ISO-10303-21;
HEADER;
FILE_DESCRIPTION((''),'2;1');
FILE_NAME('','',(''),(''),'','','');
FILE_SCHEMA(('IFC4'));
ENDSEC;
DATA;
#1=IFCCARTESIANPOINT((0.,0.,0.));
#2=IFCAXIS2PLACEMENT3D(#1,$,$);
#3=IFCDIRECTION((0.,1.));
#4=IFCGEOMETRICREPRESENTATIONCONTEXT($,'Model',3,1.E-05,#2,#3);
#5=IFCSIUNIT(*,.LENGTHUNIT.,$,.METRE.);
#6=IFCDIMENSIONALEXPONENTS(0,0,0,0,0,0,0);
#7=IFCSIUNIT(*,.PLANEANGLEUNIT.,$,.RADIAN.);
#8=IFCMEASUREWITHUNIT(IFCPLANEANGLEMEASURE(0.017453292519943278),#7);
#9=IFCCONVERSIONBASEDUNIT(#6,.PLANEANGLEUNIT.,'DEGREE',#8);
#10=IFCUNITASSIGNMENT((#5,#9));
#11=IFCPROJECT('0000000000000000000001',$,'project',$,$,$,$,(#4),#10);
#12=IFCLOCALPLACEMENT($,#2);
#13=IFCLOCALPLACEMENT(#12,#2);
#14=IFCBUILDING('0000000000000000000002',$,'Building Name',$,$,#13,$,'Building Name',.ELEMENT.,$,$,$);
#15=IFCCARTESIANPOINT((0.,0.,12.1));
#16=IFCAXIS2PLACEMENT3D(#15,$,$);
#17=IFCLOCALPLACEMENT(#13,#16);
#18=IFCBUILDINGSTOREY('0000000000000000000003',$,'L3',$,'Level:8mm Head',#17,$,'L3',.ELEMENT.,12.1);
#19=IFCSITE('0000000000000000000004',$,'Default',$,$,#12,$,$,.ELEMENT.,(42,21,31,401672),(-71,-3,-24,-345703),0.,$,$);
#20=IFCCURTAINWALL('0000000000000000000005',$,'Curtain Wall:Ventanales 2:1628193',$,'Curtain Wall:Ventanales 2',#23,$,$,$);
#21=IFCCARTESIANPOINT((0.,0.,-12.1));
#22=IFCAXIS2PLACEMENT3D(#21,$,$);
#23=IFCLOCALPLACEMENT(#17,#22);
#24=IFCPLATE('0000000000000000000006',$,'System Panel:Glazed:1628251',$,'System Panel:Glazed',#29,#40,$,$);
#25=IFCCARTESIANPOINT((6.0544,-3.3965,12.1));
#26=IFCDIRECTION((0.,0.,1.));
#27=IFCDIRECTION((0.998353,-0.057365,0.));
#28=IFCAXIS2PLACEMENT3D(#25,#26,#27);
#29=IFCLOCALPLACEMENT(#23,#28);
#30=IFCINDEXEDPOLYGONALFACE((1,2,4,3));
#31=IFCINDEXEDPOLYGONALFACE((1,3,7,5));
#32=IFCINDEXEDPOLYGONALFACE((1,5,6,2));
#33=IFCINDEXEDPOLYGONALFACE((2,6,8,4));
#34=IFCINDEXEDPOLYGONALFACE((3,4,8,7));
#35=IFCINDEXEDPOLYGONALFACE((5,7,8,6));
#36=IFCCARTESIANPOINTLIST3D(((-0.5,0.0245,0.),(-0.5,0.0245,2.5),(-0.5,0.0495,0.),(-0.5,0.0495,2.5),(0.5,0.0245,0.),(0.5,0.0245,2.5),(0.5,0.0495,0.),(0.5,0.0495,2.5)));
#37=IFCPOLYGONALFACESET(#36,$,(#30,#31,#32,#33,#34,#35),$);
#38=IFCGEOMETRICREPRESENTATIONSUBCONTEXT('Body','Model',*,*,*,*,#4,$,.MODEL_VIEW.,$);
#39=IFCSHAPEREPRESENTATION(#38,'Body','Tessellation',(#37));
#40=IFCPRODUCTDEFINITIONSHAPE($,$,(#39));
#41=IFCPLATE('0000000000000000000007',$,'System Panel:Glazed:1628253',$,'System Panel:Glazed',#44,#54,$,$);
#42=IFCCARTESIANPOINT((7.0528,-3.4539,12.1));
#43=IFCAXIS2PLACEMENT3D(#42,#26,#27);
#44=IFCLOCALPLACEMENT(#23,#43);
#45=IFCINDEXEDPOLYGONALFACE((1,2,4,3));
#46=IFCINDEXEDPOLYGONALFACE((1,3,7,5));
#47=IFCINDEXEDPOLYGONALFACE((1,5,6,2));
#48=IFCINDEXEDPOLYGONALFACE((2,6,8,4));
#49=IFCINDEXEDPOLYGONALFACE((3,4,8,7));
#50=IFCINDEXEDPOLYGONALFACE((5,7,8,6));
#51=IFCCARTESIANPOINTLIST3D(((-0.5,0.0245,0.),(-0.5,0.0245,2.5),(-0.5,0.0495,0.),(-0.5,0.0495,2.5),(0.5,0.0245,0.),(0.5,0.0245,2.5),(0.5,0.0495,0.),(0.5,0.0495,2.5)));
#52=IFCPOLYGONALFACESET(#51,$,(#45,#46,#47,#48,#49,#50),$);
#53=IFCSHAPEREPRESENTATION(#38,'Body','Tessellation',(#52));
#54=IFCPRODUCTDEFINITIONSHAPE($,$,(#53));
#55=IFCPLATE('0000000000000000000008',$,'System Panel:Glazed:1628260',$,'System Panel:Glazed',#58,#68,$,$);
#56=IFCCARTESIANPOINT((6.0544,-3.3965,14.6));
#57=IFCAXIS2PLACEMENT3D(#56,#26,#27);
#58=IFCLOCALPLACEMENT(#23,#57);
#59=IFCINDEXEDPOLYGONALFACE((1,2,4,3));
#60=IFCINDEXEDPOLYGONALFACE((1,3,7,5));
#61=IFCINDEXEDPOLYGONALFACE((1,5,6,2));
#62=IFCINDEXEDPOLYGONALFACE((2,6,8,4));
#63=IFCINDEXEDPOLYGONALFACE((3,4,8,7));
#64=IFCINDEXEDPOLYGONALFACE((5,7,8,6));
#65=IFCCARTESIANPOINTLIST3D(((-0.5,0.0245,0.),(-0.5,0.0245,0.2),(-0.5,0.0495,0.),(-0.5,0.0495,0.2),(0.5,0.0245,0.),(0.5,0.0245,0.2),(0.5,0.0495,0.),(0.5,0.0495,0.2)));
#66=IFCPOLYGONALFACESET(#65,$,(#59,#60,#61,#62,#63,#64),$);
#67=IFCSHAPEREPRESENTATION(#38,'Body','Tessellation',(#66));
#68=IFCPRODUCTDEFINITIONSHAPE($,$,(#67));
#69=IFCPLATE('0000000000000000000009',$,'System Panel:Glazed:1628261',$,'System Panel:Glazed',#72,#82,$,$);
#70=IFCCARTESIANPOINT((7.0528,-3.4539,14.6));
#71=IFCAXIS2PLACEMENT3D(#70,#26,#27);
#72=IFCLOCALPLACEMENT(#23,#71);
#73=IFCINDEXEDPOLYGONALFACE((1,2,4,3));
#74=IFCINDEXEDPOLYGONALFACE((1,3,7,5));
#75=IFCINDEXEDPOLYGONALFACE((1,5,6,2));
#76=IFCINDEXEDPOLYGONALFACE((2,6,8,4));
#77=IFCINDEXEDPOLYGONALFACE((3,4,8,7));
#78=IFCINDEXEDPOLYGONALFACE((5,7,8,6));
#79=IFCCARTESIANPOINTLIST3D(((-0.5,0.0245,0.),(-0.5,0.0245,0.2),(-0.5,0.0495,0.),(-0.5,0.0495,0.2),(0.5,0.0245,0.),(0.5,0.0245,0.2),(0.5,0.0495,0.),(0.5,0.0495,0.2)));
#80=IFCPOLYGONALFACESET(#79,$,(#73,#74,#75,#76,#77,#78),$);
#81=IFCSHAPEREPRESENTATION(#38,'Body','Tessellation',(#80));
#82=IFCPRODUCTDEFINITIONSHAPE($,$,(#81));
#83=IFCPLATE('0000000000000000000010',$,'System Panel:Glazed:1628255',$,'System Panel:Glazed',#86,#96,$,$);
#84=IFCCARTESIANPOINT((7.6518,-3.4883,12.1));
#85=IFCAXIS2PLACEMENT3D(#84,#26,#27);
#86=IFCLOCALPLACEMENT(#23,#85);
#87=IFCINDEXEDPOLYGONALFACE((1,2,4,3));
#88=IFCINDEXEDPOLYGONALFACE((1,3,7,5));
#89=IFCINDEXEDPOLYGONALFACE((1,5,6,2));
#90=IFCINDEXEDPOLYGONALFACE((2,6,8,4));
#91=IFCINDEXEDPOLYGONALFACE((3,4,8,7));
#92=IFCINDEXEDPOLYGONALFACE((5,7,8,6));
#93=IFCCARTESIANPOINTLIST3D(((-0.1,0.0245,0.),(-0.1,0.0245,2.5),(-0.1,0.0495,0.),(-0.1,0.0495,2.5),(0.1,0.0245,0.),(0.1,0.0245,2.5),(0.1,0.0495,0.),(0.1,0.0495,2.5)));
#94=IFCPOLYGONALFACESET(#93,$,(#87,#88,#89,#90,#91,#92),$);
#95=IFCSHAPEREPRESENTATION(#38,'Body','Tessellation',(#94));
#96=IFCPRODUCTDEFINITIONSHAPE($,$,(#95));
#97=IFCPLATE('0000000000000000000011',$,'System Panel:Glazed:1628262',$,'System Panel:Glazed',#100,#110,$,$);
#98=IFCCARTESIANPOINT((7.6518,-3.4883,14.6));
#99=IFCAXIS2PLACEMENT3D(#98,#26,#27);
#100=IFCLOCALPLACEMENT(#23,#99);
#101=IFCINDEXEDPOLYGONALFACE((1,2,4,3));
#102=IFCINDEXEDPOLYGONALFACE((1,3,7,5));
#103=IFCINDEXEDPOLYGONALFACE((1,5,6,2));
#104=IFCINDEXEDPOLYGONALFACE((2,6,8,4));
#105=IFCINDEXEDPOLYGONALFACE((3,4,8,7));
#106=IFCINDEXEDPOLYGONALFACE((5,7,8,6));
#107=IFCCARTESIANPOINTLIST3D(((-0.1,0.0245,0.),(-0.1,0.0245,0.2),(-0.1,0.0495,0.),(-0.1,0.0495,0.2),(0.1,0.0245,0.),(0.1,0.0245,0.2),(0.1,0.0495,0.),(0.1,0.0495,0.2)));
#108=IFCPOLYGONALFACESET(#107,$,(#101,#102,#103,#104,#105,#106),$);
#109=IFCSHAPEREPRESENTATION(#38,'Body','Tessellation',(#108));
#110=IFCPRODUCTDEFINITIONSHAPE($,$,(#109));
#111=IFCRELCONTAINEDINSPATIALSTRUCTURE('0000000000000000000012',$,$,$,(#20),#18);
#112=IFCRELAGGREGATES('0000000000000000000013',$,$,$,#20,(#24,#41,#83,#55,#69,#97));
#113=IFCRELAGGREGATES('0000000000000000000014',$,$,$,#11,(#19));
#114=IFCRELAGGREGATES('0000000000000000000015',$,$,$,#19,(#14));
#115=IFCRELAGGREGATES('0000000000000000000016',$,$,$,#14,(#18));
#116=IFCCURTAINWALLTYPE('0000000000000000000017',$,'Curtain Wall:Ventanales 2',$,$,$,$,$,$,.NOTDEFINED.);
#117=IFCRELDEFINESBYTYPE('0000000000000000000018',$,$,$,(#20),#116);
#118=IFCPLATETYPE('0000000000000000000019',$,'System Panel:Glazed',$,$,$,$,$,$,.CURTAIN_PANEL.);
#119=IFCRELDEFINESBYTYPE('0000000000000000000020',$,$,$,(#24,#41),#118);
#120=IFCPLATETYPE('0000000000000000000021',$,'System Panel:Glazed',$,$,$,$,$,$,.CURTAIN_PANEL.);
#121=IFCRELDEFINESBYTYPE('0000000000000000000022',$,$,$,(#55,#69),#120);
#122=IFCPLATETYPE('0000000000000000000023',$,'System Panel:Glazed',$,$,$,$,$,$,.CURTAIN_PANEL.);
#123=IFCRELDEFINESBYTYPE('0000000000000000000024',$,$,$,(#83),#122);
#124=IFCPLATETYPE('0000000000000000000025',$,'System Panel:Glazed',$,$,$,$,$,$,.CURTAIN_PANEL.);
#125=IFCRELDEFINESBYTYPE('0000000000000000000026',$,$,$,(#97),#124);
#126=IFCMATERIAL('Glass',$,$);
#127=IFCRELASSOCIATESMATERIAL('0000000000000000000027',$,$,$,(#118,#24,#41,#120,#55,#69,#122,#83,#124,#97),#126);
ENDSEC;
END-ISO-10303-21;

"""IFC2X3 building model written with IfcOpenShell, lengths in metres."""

from ifc_helpers import new_model, entity, si_unit, converted_unit, direction, frame, frame_2d, origin, origin_2d_with_axis, place, context, subcontext, project, spatial, rectangle, extrude, source, transform, mapped, material, type_object, type_shapes, element, aggregate, save


model = new_model("IFC2X3")

# Units and contexts
model_context = context("Model", 3, precision=1e-05, world=origin(), true_north=direction((0.0, 1.0)))
body_context = subcontext(model_context, "Body", "Model", "MODEL_VIEW")
ifc_project = project(units=[si_unit("LENGTHUNIT", "METRE"), converted_unit("PLANEANGLEUNIT", "DEGREE", entity("IfcPlaneAngleMeasure", 0.017453292519943278), si_unit("PLANEANGLEUNIT", "RADIAN"), dimensions=[0, 0, 0, 0, 0, 0, 0])], contexts=[model_context])

# Site, building, storey
site_placement = place(None, origin())
site = spatial("IfcSite", under=ifc_project, at=site_placement, Name="Default", CompositionType="ELEMENT", RefLatitude=(42, 21, 31, 401672), RefLongitude=(-71, -3, -24, -345703), RefElevation=0.0)
building_placement = place(site_placement, origin())
building = spatial("IfcBuilding", under=site, at=building_placement, Name="Building Name", LongName="Building Name", CompositionType="ELEMENT")
storey_placement = place(building_placement, frame((0.0, 0.0, 12.1)))
storey = spatial("IfcBuildingStorey", under=building, at=storey_placement, Name="L3", ObjectType="Level:8mm Head", LongName="L3", CompositionType="ELEMENT", Elevation=12.1)

# Curtain wall, plates
curtain_wall_type = type_object("IfcCurtainWallType", Name="Curtain Wall:Ventanales 2", PredefinedType="NOTDEFINED")
curtain_wall_placement = place(storey_placement, frame((0.0, 0.0, -12.1)))
curtain_wall = element("IfcCurtainWall", 1, at=curtain_wall_placement, inside=storey, type_object=curtain_wall_type, Name="Curtain Wall:Ventanales 2:1628193", ObjectType="Curtain Wall:Ventanales 2")
ifc_material_1 = material(Name="Glass")
plate_type_1 = type_object("IfcPlateType", Name="System Panel:Glazed", PredefinedType="CURTAIN_PANEL", material=ifc_material_1)
shared_shape_1 = source(origin(), body_context, "Body", "SweptSolid", [
    extrude(rectangle(XDim=0.025, YDim=1.0, at=origin_2d_with_axis()), frame((0.0, 0.037, 0.0), z_axis=(0.0, 0.0, 1.0), x_axis=(0.0, 1.0, 0.0)), (0.0, 0.0, 1.0), 2.5),
])
type_shapes(plate_type_1, [shared_shape_1])
plate_1_placement = place(curtain_wall_placement, frame((6.0544, -3.3965, 12.1), z_axis=(0.0, 0.0, 1.0), x_axis=(0.998353, -0.057365, 0.0)))
plate_1 = element("IfcPlate", 2, at=plate_1_placement, type_object=plate_type_1, material=ifc_material_1, Name="System Panel:Glazed:1628251", ObjectType="System Panel:Glazed", context=body_context, shape_type="MappedRepresentation", body=[
    mapped(shared_shape_1, transform((0.0, 0.0, 0.0), scale=1.0)),
])
plate_2_placement = place(curtain_wall_placement, frame((7.0528, -3.4539, 12.1), z_axis=(0.0, 0.0, 1.0), x_axis=(0.998353, -0.057365, 0.0)))
plate_2 = element("IfcPlate", 3, at=plate_2_placement, type_object=plate_type_1, material=ifc_material_1, Name="System Panel:Glazed:1628253", ObjectType="System Panel:Glazed", context=body_context, shape_type="MappedRepresentation", body=[
    mapped(shared_shape_1, transform((0.0, 0.0, 0.0), scale=1.0)),
])
plate_type_2 = type_object("IfcPlateType", Name="System Panel:Glazed", PredefinedType="CURTAIN_PANEL", material=ifc_material_1)
shared_shape_2 = source(origin(), body_context, "Body", "SweptSolid", [
    extrude(rectangle(XDim=0.025, YDim=1.0, at=origin_2d_with_axis()), frame((0.0, 0.037, 0.0), z_axis=(0.0, 0.0, 1.0), x_axis=(0.0, 1.0, 0.0)), (0.0, 0.0, 1.0), 0.2),
])
type_shapes(plate_type_2, [shared_shape_2])
plate_3_placement = place(curtain_wall_placement, frame((6.0544, -3.3965, 14.6), z_axis=(0.0, 0.0, 1.0), x_axis=(0.998353, -0.057365, 0.0)))
plate_3 = element("IfcPlate", 4, at=plate_3_placement, type_object=plate_type_2, material=ifc_material_1, Name="System Panel:Glazed:1628260", ObjectType="System Panel:Glazed", context=body_context, shape_type="MappedRepresentation", body=[
    mapped(shared_shape_2, transform((0.0, 0.0, 0.0), scale=1.0)),
])
plate_4_placement = place(curtain_wall_placement, frame((7.0528, -3.4539, 14.6), z_axis=(0.0, 0.0, 1.0), x_axis=(0.998353, -0.057365, 0.0)))
plate_4 = element("IfcPlate", 5, at=plate_4_placement, type_object=plate_type_2, material=ifc_material_1, Name="System Panel:Glazed:1628261", ObjectType="System Panel:Glazed", context=body_context, shape_type="MappedRepresentation", body=[
    mapped(shared_shape_2, transform((0.0, 0.0, 0.0), scale=1.0)),
])
plate_type_3 = type_object("IfcPlateType", Name="System Panel:Glazed", PredefinedType="CURTAIN_PANEL", material=ifc_material_1)
shared_shape_3 = source(origin(), body_context, "Body", "SweptSolid", [
    extrude(rectangle(XDim=0.025, YDim=0.2, at=frame_2d((0.0, 0.0), x_axis=(1.0, 0.0))), frame((0.0, 0.037, 0.0), z_axis=(0.0, 0.0, 1.0), x_axis=(0.0, 1.0, 0.0)), (0.0, 0.0, 1.0), 2.5),
])
type_shapes(plate_type_3, [shared_shape_3])
plate_5_placement = place(curtain_wall_placement, frame((7.6518, -3.4883, 12.1), z_axis=(0.0, 0.0, 1.0), x_axis=(0.998353, -0.057365, 0.0)))
plate_5 = element("IfcPlate", 6, at=plate_5_placement, type_object=plate_type_3, material=ifc_material_1, Name="System Panel:Glazed:1628255", ObjectType="System Panel:Glazed", context=body_context, shape_type="MappedRepresentation", body=[
    mapped(shared_shape_3, transform((0.0, 0.0, 0.0), scale=1.0)),
])
plate_type_4 = type_object("IfcPlateType", Name="System Panel:Glazed", PredefinedType="CURTAIN_PANEL", material=ifc_material_1)
shared_shape_4 = source(origin(), body_context, "Body", "SweptSolid", [
    extrude(rectangle(XDim=0.025, YDim=0.2, at=frame_2d((0.0, 0.0), x_axis=(1.0, 0.0))), frame((0.0, 0.037, 0.0), z_axis=(0.0, 0.0, 1.0), x_axis=(0.0, 1.0, 0.0)), (0.0, 0.0, 1.0), 0.2),
])
type_shapes(plate_type_4, [shared_shape_4])
plate_6_placement = place(curtain_wall_placement, frame((7.6518, -3.4883, 14.6), z_axis=(0.0, 0.0, 1.0), x_axis=(0.998353, -0.057365, 0.0)))
plate_6 = element("IfcPlate", 7, at=plate_6_placement, type_object=plate_type_4, material=ifc_material_1, Name="System Panel:Glazed:1628262", ObjectType="System Panel:Glazed", context=body_context, shape_type="MappedRepresentation", body=[
    mapped(shared_shape_4, transform((0.0, 0.0, 0.0), scale=1.0)),
])
aggregate(curtain_wall, [plate_1, plate_2, plate_5, plate_3, plate_4, plate_6])

save(model, "model.ifc")
